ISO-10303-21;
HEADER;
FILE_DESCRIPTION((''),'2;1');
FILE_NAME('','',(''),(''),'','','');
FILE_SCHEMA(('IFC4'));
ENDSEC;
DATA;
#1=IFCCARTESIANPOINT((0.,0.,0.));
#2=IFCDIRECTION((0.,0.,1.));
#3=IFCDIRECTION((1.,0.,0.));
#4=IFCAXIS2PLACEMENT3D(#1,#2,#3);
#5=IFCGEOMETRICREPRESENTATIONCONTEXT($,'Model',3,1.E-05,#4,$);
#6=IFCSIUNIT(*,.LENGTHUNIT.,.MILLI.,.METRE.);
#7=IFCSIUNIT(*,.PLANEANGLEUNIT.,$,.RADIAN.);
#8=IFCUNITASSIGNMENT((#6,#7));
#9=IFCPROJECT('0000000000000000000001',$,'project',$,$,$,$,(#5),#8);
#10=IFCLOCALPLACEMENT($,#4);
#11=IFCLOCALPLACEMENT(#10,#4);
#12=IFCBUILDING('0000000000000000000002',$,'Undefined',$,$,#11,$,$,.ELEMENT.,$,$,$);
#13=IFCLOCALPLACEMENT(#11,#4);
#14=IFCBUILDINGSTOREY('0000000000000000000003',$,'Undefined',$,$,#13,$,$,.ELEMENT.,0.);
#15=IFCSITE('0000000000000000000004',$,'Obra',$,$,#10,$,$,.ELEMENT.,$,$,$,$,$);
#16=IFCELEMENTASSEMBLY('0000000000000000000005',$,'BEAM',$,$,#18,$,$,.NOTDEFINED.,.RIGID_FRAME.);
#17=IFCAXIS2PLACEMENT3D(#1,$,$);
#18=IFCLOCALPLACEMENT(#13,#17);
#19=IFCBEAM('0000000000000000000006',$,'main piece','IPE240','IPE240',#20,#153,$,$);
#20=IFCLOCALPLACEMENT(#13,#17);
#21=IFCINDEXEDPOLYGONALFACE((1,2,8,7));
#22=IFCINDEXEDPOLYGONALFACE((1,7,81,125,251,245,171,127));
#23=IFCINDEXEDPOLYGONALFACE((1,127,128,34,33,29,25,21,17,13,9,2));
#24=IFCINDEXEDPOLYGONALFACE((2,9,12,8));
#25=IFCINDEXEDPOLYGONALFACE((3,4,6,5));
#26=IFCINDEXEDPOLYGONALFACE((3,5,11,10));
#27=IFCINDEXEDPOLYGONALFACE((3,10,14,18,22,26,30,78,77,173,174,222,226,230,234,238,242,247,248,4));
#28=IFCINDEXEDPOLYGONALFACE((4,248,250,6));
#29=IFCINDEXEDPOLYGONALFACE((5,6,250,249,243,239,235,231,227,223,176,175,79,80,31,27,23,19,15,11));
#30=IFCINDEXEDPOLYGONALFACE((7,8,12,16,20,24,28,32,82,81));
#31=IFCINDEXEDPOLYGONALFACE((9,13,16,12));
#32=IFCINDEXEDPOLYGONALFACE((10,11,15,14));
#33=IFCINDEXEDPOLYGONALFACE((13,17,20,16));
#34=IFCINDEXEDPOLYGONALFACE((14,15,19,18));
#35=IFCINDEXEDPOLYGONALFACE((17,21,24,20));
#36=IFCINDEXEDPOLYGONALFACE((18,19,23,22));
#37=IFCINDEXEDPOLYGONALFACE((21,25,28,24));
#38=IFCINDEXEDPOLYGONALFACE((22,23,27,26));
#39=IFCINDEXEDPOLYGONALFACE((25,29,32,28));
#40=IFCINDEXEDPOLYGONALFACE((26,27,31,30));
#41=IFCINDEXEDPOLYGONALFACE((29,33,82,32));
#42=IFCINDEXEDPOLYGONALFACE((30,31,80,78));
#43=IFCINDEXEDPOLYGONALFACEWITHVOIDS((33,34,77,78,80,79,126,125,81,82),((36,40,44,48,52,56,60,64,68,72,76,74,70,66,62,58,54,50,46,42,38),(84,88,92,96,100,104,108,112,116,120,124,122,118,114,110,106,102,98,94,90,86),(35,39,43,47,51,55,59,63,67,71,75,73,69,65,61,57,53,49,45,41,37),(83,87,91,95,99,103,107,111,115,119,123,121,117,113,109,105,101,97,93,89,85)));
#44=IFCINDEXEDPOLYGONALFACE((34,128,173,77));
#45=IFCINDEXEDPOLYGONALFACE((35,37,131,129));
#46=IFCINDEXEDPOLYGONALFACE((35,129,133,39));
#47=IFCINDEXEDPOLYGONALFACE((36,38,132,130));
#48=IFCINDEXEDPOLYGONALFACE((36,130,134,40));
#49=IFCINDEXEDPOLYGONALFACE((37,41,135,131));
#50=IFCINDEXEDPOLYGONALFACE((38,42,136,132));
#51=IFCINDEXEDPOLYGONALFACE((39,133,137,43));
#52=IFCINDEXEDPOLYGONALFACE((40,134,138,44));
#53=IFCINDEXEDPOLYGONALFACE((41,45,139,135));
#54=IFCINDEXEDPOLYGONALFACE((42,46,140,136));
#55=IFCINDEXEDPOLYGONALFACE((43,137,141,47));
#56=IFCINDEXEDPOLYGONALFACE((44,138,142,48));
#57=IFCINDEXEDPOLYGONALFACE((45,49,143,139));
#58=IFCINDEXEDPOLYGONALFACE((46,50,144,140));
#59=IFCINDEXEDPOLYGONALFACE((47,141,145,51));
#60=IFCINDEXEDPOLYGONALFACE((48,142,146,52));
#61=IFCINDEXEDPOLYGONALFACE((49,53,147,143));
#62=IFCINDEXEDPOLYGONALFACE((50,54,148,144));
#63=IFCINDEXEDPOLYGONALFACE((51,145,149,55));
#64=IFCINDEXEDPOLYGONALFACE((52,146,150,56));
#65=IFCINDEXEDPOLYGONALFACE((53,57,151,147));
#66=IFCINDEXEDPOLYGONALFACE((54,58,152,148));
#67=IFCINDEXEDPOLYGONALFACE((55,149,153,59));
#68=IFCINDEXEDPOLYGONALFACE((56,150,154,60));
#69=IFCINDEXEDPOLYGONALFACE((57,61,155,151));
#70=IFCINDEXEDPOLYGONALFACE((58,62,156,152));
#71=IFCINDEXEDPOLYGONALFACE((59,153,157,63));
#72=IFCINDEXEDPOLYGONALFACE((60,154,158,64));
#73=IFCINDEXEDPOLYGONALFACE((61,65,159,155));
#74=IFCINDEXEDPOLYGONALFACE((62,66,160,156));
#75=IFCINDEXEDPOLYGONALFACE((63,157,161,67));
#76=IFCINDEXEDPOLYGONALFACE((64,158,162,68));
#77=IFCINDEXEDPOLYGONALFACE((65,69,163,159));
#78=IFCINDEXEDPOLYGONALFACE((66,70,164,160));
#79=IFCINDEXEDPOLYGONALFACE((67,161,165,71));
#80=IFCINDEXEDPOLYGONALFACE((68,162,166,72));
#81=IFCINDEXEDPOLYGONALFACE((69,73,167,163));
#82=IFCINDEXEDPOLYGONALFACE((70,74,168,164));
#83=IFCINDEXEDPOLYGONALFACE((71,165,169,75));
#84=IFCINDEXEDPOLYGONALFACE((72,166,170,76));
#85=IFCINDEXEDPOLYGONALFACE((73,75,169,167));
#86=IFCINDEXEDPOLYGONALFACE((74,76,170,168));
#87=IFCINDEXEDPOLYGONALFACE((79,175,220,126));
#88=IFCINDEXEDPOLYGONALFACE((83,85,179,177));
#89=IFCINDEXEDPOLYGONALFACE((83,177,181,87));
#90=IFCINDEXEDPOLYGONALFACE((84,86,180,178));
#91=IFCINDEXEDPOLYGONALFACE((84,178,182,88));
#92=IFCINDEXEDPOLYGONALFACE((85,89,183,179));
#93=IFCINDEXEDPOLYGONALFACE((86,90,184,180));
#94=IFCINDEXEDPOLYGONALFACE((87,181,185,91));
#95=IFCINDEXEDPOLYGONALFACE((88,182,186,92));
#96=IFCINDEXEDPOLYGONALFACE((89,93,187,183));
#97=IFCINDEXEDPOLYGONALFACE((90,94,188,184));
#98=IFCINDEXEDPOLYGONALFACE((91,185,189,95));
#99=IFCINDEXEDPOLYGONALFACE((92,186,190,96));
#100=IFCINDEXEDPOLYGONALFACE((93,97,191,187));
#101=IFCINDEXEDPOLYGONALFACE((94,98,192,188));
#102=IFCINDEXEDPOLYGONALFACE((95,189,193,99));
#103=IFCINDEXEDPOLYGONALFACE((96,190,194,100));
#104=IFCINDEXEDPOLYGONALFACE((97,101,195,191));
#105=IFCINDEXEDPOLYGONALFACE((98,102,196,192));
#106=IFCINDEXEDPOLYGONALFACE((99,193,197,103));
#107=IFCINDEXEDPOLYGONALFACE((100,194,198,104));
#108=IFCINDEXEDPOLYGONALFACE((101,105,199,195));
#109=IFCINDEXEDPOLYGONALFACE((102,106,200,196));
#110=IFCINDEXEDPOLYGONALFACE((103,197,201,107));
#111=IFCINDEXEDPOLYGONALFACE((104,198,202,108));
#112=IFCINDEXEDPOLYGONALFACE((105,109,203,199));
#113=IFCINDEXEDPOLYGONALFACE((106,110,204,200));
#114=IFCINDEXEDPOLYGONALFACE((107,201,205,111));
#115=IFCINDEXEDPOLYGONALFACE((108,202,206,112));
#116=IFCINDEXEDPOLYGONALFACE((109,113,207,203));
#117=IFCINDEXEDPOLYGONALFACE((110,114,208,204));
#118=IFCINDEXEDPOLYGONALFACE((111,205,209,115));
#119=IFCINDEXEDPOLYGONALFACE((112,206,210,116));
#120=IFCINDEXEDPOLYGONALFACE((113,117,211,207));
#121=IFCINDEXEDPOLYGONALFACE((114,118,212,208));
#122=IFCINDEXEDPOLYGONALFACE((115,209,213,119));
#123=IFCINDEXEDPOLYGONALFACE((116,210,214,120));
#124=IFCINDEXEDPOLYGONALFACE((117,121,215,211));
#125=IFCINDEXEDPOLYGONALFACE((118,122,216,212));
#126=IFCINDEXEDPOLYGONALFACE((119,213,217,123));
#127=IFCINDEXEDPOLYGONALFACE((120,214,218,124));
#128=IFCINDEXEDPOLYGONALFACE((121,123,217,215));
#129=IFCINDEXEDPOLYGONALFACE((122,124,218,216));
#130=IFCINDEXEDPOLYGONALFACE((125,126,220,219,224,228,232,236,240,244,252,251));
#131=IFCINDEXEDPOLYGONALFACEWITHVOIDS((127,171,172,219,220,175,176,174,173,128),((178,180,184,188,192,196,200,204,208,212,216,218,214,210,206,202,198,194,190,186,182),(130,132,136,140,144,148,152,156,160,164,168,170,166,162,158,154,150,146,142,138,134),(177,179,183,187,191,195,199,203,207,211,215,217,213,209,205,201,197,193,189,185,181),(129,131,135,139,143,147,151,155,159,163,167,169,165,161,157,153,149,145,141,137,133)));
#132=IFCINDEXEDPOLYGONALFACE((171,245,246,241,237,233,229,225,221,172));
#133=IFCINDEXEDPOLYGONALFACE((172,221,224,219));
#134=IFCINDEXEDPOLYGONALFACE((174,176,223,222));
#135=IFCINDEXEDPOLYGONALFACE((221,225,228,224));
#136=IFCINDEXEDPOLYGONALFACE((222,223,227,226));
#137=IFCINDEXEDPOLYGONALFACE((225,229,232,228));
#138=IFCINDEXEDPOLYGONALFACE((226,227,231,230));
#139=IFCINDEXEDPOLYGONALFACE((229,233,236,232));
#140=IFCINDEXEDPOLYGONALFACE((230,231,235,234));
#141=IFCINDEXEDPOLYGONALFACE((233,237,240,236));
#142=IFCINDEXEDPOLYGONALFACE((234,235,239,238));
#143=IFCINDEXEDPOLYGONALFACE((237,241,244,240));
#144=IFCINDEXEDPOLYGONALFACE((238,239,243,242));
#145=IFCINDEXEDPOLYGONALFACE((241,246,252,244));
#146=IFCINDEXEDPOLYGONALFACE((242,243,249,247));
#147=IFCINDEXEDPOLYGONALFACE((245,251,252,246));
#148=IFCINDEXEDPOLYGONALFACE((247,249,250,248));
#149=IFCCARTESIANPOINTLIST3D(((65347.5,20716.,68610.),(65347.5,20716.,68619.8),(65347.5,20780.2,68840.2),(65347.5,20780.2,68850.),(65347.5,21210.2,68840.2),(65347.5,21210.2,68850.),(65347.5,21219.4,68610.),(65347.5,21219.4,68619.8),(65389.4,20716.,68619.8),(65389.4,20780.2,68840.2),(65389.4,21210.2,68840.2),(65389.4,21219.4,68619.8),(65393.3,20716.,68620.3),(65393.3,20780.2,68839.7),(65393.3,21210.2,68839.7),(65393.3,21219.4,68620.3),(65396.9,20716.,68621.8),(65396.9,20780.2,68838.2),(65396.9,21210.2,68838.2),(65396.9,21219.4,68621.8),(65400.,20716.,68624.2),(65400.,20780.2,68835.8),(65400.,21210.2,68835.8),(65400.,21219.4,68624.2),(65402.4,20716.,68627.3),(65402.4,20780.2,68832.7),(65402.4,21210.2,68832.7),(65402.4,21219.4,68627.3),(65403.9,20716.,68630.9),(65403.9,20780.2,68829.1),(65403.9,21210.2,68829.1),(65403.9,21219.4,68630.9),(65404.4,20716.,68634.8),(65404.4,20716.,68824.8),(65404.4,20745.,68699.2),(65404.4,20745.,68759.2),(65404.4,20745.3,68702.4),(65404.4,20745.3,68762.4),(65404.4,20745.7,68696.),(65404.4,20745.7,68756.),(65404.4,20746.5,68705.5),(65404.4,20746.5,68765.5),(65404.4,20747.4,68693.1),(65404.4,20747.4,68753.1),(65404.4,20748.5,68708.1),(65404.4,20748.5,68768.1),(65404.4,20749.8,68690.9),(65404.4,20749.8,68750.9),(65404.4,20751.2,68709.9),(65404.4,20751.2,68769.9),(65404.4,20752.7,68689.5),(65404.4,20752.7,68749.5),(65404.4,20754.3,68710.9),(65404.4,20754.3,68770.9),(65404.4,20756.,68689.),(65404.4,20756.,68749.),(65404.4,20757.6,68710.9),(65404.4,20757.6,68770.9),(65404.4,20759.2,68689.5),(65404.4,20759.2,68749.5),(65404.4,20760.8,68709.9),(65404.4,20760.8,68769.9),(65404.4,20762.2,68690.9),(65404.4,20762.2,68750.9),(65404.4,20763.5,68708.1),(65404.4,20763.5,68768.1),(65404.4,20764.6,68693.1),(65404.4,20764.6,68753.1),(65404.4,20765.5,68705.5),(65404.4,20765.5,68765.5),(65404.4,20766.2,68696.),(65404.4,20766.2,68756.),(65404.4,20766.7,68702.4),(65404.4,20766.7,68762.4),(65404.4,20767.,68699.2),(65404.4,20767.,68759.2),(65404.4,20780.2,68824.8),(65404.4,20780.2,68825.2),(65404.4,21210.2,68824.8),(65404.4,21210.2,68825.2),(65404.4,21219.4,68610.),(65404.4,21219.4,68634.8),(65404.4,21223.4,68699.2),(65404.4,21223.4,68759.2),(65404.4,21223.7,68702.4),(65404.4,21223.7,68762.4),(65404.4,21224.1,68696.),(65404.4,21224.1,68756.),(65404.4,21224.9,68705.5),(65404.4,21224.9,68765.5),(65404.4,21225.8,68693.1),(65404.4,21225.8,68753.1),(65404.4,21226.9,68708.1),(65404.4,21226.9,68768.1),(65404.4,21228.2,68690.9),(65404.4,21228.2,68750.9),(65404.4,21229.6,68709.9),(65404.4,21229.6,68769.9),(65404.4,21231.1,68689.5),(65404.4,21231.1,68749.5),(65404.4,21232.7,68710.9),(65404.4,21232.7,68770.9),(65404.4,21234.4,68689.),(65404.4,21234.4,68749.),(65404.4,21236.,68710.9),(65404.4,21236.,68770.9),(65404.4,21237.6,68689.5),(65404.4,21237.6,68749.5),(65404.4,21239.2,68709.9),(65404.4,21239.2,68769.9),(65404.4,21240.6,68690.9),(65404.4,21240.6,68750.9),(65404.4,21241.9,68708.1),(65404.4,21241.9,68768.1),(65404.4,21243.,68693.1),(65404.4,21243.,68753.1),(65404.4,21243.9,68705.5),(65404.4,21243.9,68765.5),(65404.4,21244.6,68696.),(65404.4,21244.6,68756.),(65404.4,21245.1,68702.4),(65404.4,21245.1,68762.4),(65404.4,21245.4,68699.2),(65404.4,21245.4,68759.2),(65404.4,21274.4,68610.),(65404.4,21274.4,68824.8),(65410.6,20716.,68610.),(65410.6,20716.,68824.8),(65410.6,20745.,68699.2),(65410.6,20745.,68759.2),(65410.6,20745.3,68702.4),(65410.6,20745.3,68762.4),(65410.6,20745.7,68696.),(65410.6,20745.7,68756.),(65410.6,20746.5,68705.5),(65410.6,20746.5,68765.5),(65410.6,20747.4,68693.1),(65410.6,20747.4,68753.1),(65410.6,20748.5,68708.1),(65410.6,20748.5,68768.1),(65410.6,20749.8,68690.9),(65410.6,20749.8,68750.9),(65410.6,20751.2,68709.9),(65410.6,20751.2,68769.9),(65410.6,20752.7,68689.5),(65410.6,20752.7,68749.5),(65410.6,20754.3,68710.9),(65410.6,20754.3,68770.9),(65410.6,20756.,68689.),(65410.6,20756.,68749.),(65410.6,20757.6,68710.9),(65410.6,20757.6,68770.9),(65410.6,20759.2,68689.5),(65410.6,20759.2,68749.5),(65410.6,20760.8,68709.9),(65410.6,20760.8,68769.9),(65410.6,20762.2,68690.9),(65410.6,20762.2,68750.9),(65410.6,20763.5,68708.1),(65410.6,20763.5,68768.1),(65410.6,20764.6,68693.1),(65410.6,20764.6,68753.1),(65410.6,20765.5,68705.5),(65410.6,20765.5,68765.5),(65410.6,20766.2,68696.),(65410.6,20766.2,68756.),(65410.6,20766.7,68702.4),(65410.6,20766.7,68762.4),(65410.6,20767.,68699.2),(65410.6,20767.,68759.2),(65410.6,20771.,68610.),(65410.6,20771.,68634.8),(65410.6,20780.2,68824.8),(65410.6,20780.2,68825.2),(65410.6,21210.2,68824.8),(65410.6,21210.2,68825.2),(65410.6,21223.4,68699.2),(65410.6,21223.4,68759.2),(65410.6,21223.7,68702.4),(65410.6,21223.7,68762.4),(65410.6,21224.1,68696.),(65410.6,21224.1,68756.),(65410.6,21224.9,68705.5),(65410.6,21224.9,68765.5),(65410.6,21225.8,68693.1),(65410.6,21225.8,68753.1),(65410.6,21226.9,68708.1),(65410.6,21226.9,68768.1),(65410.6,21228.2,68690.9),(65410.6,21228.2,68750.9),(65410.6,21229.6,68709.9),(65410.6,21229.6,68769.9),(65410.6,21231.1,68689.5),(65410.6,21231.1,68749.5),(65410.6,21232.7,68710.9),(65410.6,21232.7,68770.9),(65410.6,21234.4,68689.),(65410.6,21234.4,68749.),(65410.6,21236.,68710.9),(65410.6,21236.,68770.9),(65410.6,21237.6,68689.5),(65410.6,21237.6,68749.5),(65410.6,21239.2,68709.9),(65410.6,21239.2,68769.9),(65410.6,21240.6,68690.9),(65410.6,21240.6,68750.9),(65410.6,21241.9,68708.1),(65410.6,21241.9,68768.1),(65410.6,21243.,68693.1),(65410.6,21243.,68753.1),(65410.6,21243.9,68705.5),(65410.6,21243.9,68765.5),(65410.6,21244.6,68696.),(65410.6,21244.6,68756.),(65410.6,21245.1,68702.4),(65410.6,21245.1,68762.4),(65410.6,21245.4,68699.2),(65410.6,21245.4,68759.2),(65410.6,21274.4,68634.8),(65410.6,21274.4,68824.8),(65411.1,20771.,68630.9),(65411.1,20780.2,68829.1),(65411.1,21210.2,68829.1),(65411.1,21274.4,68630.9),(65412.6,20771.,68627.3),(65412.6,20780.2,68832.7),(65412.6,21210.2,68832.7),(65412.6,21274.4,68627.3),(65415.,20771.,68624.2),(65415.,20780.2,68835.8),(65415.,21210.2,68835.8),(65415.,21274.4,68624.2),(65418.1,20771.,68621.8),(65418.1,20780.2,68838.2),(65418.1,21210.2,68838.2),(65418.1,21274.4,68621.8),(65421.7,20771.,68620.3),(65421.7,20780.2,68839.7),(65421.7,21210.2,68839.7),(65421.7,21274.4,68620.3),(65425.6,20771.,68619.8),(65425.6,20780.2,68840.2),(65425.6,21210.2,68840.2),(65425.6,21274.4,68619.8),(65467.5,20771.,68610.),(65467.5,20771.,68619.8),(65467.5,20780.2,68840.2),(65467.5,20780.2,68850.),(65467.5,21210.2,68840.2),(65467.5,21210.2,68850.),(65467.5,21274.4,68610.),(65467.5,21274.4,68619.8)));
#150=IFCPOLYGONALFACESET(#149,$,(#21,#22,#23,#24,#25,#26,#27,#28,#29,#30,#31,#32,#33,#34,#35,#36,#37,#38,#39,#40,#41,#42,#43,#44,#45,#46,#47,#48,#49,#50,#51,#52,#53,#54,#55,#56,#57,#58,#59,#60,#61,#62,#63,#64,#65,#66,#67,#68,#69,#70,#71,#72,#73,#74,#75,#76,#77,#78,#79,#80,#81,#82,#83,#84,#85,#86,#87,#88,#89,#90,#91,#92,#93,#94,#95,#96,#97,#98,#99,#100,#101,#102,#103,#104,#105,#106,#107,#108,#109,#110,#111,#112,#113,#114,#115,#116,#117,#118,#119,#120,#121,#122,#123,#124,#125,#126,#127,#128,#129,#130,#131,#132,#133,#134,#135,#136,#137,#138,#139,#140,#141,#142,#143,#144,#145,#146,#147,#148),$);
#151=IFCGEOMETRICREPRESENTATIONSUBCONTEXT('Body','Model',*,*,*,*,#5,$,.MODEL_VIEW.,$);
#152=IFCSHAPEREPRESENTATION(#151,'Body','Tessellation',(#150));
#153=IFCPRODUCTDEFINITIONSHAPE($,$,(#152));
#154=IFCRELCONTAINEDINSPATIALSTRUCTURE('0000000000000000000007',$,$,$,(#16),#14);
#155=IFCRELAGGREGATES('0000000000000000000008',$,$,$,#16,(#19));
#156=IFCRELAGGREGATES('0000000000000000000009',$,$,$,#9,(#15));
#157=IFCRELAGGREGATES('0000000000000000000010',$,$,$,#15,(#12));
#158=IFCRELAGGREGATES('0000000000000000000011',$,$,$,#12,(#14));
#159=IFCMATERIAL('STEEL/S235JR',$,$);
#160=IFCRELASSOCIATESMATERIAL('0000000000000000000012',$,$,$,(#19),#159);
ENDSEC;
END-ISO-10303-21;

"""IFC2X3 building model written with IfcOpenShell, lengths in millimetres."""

from ifc_helpers import new_model, si_unit, frame, origin_with_axes, origin_2d_with_axis, place, context, subcontext, project, spatial, rectangle, circle, i_section, extrude, clip, halfspace, source, transform, mapped, material, element, aggregate, save


model = new_model("IFC2X3")

# Units and contexts
model_context = context("Model", 3, precision=1e-05, world=origin_with_axes())
body_context = subcontext(model_context, "Body", "Model", "MODEL_VIEW")
ifc_project = project(units=[si_unit("LENGTHUNIT", "METRE", prefix="MILLI"), si_unit("PLANEANGLEUNIT", "RADIAN")], contexts=[model_context])

# Site, building, storey
site_placement = place(None, origin_with_axes())
site = spatial("IfcSite", under=ifc_project, at=site_placement, Name="Obra", CompositionType="ELEMENT")
building_placement = place(site_placement, origin_with_axes())
building = spatial("IfcBuilding", under=site, at=building_placement, Name="Undefined", CompositionType="ELEMENT")
storey_placement = place(building_placement, origin_with_axes())
storey = spatial("IfcBuildingStorey", under=building, at=storey_placement, Name="Undefined", CompositionType="ELEMENT", Elevation=0.0)

# Shared definitions
ifc_material_1 = material(Name="STEEL/S235JR")

# Element assembly, beam, openings
shared_shape_1 = source(origin_with_axes(), body_context, "Body", "SweptSolid", [
    extrude(circle(Radius=11.0, at=origin_2d_with_axis()), frame((0.0, -3.2, 0.0), z_axis=(0.0, 1.0, 0.0), x_axis=(1.0, 0.0, 0.0)), (0.0, 0.0, 1.0), 6.4),
])
assembly_1_placement = place(storey_placement, origin_with_axes())
assembly_1 = element("IfcElementAssembly", 1, at=assembly_1_placement, inside=storey, Name="BEAM", AssemblyPlace="NOTDEFINED", PredefinedType="RIGID_FRAME")
beam_1_placement = place(assembly_1_placement, frame((65407.5, 20782.9, 68730.0), z_axis=(0.0, 0.0, 1.0), x_axis=(0.0, 1.0, 0.0)))
beam_1 = element("IfcBeam", 2, at=beam_1_placement, material=ifc_material_1, Name="main piece", Description="IPE240", ObjectType="IPE240", context=body_context, shape_type="Clipping", body=[
    clip(clip(extrude(i_section(OverallWidth=120.0, OverallDepth=240.0, WebThickness=6.2, FlangeThickness=9.8, FilletRadius=15.0, at=origin_2d_with_axis()), frame((491.4, 0.0, 0.0), z_axis=(-1.0, 0.0, 0.0), x_axis=(0.0, -1.0, 0.0)), (0.0, 0.0, 1.0), 558.4), halfspace(frame((491.4, 0.0, -220.0), z_axis=(-1.0, -0.000002, 0.0), x_axis=(-0.000002, 1.0, 0.0)), True)), halfspace(frame((-66.9, 0.0, -220.0), z_axis=(1.0, 0.000001, 0.0), x_axis=(0.000002, -1.0, 0.0)), True)),
])
opening_1_placement = place(assembly_1_placement, frame((65407.5, 20782.9, 68730.0), z_axis=(0.0, 0.0, 1.0), x_axis=(0.0, 1.0, 0.0)))
element("IfcOpeningElement", 3, at=opening_1_placement, cuts=beam_1, ObjectType="Recess", context=body_context, shape_type="SweptSolid", body=[
    extrude(rectangle(XDim=65.0, YDim=300.0, at=origin_2d_with_axis()), frame((-44.4, -153.1, 109.8), z_axis=(0.0, 0.0, -1.0), x_axis=(1.0, 0.000001, 0.0)), (0.0, 0.0, 1.0), 249.6),
])
opening_2_placement = place(assembly_1_placement, frame((65407.5, 20782.9, 68730.0), z_axis=(0.0, 0.0, 1.0), x_axis=(0.0, 1.0, 0.0)))
element("IfcOpeningElement", 4, at=opening_2_placement, cuts=beam_1, ObjectType="Recess", context=body_context, shape_type="SweptSolid", body=[
    extrude(rectangle(XDim=26.2, YDim=76.2, at=origin_2d_with_axis()), frame((-40.8, -61.0, 107.9), z_axis=(-0.000002, 1.0, 0.0), x_axis=(0.0, 0.0, -1.0)), (0.0, 0.0, 1.0), 122.0),
])
opening_3_placement = place(assembly_1_placement, frame((65407.5, 20782.9, 68730.0), z_axis=(0.0, 0.0, 1.0), x_axis=(0.0, 1.0, 0.0)))
element("IfcOpeningElement", 5, at=opening_3_placement, cuts=beam_1, ObjectType="Recess", context=body_context, shape_type="SweptSolid", body=[
    extrude(rectangle(XDim=65.0, YDim=300.0, at=origin_2d_with_axis()), frame((468.9, 153.1, 109.8), z_axis=(0.0, 0.0, -1.0), x_axis=(-1.0, -0.000002, 0.0)), (0.0, 0.0, 1.0), 249.6),
])
opening_4_placement = place(assembly_1_placement, frame((65407.5, 20782.9, 68730.0), z_axis=(0.0, 0.0, 1.0), x_axis=(0.0, 1.0, 0.0)))
element("IfcOpeningElement", 6, at=opening_4_placement, cuts=beam_1, ObjectType="Recess", context=body_context, shape_type="SweptSolid", body=[
    extrude(rectangle(XDim=26.2, YDim=76.2, at=origin_2d_with_axis()), frame((465.3, 61.0, 107.9), z_axis=(0.000002, -1.0, 0.0), x_axis=(0.0, 0.0, -1.0)), (0.0, 0.0, 1.0), 122.0),
])
opening_5_placement = place(assembly_1_placement, frame((65407.5, 20716.0, 68850.0), z_axis=(-0.000002, 1.0, 0.0), x_axis=(0.0, 0.0, -1.0)))
element("IfcOpeningElement", 7, at=opening_5_placement, cuts=beam_1, ObjectType="Opening", context=body_context, shape_type="MappedRepresentation", body=[
    mapped(shared_shape_1, transform((90.0, 0.0, 40.0))),
    mapped(shared_shape_1, transform((150.0, 0.0, 40.0))),
])
opening_6_placement = place(assembly_1_placement, frame((65407.5, 21274.4, 68850.0), z_axis=(0.000002, -1.0, 0.0), x_axis=(0.0, 0.0, -1.0)))
element("IfcOpeningElement", 8, at=opening_6_placement, cuts=beam_1, ObjectType="Opening", context=body_context, shape_type="MappedRepresentation", body=[
    mapped(shared_shape_1, transform((90.0, 0.0, 40.0))),
    mapped(shared_shape_1, transform((150.0, 0.0, 40.0))),
])
aggregate(assembly_1, [beam_1])

save(model, "model.ifc")
